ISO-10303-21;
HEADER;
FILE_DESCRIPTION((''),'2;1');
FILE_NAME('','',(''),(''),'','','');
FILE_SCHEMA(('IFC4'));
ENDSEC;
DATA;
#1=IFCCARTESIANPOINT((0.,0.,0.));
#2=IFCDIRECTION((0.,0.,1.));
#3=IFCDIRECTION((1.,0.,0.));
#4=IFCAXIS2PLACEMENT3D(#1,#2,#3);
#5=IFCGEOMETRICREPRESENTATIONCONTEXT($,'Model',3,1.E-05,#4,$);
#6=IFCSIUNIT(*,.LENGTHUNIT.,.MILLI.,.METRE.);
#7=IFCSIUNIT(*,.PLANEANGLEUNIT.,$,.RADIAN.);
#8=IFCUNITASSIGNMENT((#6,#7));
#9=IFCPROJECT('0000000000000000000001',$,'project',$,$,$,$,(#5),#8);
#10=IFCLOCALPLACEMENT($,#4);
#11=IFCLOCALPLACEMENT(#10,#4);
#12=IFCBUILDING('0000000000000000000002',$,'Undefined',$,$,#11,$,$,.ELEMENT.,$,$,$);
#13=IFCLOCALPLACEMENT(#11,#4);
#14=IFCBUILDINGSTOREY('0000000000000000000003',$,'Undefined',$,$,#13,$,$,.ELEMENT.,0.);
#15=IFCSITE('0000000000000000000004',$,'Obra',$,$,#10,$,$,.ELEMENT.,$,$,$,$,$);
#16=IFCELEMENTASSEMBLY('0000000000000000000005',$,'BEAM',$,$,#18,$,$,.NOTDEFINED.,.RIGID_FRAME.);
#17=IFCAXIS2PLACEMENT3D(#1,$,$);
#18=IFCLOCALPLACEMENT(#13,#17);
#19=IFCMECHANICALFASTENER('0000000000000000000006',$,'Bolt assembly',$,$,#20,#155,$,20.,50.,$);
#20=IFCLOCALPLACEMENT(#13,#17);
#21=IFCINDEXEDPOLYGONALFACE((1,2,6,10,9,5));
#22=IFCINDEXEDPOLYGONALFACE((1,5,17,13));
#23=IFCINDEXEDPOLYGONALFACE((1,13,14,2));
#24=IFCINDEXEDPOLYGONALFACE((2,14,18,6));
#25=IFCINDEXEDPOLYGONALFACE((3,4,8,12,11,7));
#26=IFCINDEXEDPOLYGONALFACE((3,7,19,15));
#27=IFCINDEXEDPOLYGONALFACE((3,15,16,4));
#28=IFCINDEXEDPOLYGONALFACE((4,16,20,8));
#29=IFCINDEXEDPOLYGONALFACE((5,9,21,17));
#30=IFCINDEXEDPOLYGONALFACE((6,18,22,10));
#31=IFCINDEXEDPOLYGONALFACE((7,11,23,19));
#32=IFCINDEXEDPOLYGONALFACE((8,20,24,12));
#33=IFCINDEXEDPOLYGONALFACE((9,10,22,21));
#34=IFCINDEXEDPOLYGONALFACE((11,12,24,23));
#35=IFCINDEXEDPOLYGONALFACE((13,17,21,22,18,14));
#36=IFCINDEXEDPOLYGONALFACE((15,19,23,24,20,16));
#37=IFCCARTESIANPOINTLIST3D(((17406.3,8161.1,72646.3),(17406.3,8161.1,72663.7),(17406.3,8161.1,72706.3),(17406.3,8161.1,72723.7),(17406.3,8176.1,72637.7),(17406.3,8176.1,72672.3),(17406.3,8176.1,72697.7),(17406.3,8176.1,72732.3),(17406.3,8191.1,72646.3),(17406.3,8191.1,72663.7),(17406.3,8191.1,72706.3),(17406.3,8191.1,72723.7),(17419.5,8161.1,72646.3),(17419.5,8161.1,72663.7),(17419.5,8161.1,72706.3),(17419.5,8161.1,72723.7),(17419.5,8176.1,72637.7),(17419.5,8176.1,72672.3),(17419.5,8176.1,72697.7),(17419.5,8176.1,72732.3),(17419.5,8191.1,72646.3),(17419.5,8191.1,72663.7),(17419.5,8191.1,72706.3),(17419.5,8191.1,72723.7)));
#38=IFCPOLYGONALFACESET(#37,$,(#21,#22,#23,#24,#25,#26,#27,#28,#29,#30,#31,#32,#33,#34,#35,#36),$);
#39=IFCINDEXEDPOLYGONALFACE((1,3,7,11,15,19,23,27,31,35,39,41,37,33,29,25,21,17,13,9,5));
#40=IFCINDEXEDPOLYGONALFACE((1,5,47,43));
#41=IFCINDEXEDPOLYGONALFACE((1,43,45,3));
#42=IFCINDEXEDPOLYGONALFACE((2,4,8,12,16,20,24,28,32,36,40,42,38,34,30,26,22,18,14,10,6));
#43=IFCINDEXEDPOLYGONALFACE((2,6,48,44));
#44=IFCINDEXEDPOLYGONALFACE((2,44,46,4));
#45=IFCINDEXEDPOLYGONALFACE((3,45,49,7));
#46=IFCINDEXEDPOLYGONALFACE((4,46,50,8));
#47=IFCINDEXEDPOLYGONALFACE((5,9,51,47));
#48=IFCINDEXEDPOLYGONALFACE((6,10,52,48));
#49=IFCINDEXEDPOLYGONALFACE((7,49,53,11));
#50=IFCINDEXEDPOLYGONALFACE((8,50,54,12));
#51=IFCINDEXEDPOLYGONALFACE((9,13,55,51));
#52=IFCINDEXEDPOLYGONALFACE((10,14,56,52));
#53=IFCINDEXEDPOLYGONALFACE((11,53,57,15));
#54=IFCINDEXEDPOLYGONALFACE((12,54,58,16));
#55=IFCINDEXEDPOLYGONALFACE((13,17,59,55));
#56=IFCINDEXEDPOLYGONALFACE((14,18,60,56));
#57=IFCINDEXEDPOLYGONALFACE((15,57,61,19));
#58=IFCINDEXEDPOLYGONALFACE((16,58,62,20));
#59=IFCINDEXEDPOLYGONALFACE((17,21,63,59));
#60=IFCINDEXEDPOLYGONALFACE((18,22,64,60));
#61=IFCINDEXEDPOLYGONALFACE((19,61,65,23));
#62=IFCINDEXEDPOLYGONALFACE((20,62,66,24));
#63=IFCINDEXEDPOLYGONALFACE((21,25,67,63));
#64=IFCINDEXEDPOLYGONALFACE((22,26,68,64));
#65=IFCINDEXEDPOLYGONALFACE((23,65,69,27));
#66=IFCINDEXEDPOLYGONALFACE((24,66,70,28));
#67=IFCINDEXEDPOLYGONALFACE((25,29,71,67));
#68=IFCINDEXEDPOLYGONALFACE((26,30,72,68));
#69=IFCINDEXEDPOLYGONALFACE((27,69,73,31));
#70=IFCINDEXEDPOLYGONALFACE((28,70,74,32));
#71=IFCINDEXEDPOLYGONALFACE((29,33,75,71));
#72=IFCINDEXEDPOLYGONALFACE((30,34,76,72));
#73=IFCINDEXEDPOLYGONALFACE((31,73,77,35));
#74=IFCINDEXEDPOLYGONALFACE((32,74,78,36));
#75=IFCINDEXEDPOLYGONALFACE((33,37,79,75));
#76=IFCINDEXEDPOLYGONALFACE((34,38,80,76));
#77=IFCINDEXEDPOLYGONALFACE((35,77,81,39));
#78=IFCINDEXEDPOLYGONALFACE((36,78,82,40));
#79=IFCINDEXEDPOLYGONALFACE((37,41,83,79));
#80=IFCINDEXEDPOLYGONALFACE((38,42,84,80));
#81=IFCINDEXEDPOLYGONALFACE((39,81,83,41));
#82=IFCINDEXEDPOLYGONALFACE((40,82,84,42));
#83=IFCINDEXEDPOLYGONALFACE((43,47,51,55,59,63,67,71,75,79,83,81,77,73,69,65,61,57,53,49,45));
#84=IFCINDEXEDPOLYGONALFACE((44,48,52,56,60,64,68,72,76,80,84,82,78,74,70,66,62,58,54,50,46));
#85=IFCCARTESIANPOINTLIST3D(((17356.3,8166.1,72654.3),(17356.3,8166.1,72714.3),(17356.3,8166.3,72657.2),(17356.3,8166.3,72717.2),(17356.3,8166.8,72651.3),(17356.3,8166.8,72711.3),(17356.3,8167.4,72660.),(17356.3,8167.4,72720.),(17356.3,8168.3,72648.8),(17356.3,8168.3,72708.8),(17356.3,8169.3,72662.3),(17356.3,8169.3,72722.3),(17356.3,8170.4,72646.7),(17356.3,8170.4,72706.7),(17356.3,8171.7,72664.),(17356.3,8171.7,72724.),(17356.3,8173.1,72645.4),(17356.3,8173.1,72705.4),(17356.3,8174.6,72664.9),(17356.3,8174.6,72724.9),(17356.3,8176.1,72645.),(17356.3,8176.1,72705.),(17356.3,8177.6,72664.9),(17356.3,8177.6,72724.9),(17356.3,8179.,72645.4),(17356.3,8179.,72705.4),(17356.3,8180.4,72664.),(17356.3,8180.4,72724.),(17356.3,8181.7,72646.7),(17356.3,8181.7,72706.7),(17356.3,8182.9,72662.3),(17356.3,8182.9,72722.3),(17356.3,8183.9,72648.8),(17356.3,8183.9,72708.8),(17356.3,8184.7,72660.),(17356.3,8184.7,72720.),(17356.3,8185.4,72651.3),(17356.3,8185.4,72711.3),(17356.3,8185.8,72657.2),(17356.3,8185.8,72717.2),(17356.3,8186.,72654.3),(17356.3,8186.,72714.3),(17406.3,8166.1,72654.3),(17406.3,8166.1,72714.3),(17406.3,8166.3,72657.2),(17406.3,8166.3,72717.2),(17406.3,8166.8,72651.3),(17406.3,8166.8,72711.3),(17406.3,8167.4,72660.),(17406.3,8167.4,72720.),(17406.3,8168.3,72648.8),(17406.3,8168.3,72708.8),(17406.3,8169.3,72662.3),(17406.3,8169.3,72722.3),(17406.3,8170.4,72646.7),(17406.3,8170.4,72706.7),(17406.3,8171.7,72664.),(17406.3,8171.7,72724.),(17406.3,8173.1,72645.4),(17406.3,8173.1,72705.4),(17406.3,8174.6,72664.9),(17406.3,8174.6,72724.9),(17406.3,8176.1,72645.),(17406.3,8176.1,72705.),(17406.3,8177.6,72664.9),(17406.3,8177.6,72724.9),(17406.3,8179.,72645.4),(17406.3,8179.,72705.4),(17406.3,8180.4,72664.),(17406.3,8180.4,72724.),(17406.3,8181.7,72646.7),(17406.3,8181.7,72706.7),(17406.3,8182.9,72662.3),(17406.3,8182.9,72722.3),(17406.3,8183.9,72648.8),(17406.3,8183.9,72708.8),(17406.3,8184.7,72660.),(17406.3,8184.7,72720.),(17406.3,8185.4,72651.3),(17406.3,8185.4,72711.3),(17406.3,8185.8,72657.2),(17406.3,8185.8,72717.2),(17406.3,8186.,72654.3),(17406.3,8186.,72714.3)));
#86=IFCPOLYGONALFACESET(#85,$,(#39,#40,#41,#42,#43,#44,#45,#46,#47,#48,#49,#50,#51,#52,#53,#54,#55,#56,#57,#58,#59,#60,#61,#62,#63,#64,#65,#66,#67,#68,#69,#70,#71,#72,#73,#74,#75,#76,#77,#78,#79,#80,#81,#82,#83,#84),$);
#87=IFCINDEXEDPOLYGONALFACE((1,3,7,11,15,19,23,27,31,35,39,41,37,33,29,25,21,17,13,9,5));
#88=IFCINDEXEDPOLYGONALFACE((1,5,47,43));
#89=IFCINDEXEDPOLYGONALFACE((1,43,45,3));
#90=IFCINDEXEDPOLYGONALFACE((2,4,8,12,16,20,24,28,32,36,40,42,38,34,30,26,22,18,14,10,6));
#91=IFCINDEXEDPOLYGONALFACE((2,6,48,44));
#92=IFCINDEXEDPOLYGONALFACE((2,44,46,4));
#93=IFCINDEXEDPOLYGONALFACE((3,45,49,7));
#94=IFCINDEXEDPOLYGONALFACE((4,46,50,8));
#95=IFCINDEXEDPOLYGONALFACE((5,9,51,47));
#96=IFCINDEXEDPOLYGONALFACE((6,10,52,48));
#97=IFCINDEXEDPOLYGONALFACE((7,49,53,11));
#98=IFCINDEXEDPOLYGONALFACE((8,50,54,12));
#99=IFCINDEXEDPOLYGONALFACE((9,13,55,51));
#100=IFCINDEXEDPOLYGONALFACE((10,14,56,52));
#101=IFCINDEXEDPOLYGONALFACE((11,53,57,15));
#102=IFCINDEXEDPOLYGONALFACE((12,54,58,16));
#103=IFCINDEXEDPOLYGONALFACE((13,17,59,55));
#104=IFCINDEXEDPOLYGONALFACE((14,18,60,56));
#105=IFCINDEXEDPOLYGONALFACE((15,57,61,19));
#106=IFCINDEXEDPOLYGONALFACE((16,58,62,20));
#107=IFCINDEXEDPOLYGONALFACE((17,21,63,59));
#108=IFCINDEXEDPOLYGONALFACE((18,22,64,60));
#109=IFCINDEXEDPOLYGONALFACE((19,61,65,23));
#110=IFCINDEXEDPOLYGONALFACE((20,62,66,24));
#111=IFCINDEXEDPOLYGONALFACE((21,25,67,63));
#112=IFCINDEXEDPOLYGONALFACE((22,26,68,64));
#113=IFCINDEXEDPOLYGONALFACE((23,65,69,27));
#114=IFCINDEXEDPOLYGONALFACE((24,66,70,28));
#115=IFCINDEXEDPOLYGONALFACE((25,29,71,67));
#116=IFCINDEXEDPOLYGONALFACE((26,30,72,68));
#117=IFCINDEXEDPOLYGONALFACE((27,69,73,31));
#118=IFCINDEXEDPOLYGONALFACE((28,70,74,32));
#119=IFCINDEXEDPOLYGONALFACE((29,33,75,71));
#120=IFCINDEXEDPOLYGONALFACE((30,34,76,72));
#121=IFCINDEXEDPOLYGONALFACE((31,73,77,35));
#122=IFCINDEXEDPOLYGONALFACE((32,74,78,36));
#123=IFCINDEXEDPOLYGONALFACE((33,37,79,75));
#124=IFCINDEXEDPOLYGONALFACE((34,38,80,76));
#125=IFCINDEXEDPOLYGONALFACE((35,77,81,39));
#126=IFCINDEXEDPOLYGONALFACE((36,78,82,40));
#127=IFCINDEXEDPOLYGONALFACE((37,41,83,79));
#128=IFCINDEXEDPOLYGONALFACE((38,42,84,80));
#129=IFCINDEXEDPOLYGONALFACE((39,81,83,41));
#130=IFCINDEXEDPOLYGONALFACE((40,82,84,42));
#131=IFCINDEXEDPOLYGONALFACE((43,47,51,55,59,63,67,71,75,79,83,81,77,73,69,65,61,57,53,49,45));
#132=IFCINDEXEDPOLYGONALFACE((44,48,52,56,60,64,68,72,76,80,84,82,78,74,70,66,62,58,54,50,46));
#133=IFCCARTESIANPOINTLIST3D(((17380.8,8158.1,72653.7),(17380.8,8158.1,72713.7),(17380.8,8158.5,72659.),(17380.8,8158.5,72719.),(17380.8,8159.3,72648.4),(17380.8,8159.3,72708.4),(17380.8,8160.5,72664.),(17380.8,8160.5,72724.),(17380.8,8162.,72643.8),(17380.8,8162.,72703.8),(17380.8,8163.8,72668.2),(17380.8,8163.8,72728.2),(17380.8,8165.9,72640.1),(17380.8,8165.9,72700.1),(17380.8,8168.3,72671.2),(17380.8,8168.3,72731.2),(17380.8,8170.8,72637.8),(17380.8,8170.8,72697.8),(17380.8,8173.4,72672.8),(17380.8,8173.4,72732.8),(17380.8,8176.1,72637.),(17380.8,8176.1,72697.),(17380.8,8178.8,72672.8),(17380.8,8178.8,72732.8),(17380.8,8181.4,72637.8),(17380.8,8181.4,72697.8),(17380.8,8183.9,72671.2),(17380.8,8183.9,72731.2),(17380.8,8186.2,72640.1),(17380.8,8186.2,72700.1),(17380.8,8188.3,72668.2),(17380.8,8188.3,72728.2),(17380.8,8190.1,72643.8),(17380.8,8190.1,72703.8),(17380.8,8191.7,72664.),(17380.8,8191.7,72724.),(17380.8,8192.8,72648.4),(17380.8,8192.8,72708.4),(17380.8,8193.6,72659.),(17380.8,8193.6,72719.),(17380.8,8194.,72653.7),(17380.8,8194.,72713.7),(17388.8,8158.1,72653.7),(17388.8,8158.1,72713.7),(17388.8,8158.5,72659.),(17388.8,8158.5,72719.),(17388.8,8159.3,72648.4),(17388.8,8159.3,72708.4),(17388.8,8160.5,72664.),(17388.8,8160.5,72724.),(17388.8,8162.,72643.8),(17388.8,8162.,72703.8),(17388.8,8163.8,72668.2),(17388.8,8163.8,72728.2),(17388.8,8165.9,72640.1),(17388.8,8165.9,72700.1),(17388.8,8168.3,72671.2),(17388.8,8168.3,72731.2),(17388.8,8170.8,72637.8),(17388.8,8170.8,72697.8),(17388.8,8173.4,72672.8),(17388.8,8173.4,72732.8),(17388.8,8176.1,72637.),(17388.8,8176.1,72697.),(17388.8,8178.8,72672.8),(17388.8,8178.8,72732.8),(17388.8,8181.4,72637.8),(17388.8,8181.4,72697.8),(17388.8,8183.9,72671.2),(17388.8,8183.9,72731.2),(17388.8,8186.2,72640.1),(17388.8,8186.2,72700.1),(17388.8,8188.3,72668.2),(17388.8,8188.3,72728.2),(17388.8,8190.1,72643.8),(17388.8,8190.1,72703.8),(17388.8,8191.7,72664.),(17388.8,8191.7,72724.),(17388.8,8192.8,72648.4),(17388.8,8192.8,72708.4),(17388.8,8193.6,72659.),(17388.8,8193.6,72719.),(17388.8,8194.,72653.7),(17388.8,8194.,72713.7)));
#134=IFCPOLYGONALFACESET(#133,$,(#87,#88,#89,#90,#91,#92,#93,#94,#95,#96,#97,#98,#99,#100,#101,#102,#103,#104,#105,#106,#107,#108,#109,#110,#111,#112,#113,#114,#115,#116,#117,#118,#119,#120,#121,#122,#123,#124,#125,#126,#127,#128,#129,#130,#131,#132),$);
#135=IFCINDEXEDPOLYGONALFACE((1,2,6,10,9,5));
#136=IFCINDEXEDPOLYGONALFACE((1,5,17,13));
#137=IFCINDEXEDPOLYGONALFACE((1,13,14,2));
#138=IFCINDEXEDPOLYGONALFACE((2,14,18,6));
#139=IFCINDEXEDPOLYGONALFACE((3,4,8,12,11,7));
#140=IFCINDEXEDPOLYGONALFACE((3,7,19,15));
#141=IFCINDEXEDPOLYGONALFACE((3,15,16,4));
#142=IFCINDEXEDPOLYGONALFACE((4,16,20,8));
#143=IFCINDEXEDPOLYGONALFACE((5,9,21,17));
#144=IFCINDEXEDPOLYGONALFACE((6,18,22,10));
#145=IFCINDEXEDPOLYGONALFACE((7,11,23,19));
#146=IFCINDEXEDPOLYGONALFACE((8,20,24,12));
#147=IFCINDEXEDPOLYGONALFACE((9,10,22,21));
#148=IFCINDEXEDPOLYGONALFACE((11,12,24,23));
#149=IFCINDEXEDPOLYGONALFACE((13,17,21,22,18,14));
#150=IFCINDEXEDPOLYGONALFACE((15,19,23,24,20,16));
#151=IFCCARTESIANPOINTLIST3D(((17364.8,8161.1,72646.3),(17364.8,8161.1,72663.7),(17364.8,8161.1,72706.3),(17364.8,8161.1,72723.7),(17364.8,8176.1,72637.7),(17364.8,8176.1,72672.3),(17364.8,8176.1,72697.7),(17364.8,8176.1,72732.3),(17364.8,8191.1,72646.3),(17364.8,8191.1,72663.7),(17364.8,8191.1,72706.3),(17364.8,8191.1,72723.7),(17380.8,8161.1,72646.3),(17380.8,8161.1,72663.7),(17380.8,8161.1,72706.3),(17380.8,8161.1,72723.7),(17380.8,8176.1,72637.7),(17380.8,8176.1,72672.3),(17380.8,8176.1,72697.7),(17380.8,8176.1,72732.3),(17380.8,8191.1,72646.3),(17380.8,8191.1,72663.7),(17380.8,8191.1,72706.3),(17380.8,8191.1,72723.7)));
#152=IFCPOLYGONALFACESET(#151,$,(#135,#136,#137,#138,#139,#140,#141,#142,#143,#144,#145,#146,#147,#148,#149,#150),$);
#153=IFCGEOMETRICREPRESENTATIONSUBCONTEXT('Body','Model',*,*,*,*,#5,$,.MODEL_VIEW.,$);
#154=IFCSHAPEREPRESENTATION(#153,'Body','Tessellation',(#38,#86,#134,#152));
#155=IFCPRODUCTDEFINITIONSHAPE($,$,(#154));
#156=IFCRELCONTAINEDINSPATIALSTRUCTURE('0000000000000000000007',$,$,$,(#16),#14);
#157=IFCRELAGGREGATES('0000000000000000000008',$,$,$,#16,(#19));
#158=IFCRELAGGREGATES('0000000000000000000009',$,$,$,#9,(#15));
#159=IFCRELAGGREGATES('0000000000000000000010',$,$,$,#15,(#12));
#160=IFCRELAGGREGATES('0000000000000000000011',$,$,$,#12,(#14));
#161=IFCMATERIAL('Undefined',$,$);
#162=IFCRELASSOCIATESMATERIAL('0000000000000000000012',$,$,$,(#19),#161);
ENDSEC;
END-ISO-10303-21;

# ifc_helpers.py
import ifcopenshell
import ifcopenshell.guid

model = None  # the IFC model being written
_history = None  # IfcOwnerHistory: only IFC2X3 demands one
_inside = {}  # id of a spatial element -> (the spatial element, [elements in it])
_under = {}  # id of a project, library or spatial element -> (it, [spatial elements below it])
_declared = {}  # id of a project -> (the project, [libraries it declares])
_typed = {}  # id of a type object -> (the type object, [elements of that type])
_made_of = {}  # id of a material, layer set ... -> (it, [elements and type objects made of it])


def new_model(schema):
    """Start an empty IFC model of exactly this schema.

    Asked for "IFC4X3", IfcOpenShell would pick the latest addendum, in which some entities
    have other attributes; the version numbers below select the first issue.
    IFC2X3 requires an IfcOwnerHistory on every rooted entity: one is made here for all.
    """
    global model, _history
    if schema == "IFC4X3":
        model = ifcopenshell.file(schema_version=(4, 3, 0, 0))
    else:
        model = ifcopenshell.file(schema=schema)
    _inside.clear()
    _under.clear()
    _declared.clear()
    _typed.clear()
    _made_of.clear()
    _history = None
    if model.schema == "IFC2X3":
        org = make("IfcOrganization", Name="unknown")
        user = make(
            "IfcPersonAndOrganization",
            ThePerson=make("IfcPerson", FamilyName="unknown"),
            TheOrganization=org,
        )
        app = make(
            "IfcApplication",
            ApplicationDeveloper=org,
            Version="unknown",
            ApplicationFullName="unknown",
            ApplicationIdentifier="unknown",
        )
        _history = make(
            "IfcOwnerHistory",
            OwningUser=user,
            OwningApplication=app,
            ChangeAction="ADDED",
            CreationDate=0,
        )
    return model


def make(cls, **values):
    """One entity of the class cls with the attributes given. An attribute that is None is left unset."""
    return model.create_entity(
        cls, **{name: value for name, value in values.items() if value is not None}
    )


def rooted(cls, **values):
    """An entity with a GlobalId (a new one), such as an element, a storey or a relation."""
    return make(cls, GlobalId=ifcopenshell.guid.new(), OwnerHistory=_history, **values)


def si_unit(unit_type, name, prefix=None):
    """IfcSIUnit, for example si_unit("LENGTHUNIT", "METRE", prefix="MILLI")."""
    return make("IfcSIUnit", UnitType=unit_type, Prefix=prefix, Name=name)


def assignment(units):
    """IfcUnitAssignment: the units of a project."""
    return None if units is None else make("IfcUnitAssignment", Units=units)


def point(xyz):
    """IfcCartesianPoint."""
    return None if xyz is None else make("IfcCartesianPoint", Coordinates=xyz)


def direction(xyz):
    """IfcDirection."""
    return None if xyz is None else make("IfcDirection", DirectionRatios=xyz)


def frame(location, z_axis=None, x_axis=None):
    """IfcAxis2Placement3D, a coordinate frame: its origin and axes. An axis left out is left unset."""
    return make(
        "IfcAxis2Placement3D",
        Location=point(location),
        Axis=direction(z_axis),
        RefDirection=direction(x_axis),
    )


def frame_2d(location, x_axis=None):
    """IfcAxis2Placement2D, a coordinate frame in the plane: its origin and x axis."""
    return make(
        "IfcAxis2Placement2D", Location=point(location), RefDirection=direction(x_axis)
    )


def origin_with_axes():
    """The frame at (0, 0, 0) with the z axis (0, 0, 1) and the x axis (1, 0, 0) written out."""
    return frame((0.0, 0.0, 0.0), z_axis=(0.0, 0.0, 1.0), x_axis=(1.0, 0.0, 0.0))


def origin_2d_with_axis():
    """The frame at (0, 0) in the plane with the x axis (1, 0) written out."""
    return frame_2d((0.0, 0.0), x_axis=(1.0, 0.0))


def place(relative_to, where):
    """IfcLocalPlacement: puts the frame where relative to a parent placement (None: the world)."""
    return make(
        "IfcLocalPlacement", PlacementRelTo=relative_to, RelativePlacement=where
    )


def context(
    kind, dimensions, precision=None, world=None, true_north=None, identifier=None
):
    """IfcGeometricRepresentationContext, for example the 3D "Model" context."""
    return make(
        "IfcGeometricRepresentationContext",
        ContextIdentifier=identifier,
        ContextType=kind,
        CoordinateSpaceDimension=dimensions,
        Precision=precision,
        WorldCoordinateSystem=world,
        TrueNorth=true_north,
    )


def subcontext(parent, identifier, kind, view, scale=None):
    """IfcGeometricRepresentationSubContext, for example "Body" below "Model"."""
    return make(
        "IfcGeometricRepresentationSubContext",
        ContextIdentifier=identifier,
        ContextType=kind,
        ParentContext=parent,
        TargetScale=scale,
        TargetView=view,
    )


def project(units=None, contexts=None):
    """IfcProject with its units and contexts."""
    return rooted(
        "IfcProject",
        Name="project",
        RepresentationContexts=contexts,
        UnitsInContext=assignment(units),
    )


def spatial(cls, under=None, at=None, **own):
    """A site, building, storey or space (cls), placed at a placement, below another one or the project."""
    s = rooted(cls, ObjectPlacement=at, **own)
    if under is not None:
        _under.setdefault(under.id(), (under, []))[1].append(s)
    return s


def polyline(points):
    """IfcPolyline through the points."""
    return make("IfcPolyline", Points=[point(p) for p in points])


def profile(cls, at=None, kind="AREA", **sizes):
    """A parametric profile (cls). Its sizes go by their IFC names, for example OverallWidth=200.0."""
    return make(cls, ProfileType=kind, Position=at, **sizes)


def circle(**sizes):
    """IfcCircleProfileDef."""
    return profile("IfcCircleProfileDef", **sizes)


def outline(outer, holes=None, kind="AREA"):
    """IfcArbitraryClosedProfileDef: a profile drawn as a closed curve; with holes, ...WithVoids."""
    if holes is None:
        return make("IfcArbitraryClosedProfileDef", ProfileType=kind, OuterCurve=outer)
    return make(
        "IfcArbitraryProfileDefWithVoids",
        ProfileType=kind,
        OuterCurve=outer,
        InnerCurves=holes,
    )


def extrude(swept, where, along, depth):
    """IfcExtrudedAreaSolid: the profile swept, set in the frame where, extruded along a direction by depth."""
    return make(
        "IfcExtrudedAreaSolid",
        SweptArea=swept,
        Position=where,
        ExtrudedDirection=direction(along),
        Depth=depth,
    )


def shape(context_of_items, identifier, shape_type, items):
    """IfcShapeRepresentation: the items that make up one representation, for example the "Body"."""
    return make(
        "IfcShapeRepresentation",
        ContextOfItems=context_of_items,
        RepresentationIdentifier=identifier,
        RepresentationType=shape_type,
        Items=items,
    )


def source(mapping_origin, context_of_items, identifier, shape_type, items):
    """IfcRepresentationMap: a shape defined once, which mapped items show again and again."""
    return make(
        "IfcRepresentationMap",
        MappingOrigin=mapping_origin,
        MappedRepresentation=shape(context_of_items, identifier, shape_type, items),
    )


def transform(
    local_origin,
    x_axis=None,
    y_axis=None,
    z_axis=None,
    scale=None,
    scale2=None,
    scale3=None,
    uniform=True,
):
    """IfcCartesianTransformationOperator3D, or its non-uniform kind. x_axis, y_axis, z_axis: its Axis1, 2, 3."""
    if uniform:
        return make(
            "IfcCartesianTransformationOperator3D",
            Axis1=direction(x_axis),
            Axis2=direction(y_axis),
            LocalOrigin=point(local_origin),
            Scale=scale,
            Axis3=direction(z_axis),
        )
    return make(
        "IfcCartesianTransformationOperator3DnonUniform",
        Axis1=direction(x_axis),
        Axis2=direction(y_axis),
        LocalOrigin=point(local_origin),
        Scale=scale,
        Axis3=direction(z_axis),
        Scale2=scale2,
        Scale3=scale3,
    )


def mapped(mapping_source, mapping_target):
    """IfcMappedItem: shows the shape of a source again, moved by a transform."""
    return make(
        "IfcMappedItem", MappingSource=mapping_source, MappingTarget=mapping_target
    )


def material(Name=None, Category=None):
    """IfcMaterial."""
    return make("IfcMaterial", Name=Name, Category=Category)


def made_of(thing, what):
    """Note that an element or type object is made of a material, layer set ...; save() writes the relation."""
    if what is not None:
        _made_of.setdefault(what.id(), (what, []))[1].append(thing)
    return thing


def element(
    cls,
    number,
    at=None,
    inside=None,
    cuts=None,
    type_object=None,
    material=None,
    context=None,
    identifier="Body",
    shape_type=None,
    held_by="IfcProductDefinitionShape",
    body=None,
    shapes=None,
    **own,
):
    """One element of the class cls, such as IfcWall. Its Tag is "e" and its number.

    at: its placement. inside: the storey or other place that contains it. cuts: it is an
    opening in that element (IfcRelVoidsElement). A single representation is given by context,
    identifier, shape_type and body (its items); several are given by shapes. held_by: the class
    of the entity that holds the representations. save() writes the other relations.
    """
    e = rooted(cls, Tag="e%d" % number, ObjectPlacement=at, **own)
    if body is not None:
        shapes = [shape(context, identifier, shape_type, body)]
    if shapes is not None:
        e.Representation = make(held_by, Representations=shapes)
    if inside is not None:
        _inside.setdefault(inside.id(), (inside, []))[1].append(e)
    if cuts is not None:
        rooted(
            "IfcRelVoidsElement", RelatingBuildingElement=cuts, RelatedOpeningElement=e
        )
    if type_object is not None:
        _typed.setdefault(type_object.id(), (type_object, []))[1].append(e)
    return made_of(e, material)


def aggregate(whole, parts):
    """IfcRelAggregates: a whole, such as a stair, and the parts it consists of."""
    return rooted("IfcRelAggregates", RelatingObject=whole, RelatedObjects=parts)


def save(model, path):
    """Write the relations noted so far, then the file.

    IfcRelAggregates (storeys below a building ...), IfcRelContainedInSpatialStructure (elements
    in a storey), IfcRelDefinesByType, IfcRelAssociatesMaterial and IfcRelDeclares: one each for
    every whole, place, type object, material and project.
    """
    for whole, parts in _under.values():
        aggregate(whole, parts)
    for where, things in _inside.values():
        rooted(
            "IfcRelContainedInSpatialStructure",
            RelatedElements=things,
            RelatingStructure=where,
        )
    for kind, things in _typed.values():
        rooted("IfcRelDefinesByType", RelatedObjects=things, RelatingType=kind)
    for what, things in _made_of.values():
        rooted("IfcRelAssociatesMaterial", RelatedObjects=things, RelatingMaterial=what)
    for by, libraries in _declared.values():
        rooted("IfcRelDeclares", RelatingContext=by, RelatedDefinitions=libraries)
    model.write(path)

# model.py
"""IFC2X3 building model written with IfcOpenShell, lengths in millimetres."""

from ifc_helpers import new_model, si_unit, frame, origin_with_axes, origin_2d_with_axis, place, context, subcontext, project, spatial, polyline, circle, outline, extrude, source, transform, mapped, material, element, aggregate, save


model = new_model("IFC2X3")

# Units and contexts
model_context = context("Model", 3, precision=1e-05, world=origin_with_axes())
body_context = subcontext(model_context, "Body", "Model", "MODEL_VIEW")
ifc_project = project(units=[si_unit("LENGTHUNIT", "METRE", prefix="MILLI"), si_unit("PLANEANGLEUNIT", "RADIAN")], contexts=[model_context])

# Site, building, storey
site_placement = place(None, origin_with_axes())
site = spatial("IfcSite", under=ifc_project, at=site_placement, Name="Obra", CompositionType="ELEMENT")
building_placement = place(site_placement, origin_with_axes())
building = spatial("IfcBuilding", under=site, at=building_placement, Name="Undefined", CompositionType="ELEMENT")
storey_placement = place(building_placement, origin_with_axes())
storey = spatial("IfcBuildingStorey", under=building, at=storey_placement, Name="Undefined", CompositionType="ELEMENT", Elevation=0.0)

# Shared definitions
ifc_material = material(Name="Undefined")

# Shared definitions
shared_shape_1 = source(origin_with_axes(), body_context, "Body", "SweptSolid", [
    extrude(outline(polyline([(17.3, 0.0), (8.7, 15.0), (-8.7, 15.0), (-17.3, 0.0), (-8.7, -15.0), (8.7, -15.0), (17.3, 0.0)])), frame((0.0, -27.0, 0.0), z_axis=(0.0, 1.0, 0.0), x_axis=(1.0, 0.0, 0.0)), (0.0, 0.0, 1.0), 13.2),
    extrude(circle(Radius=10.0, at=origin_2d_with_axis()), frame((0.0, -13.8, 0.0), z_axis=(0.0, 1.0, 0.0), x_axis=(1.0, 0.0, 0.0)), (0.0, 0.0, 1.0), 50.0),
    extrude(circle(Radius=18.0, at=origin_2d_with_axis()), frame((0.0, 3.7, 0.0), z_axis=(0.0, 1.0, 0.0), x_axis=(1.0, 0.0, 0.0)), (0.0, 0.0, 1.0), 8.0),
    extrude(outline(polyline([(17.3, 0.0), (8.7, 15.0), (-8.7, 15.0), (-17.3, 0.0), (-8.7, -15.0), (8.7, -15.0), (17.3, 0.0)])), frame((0.0, 11.7, 0.0), z_axis=(0.0, 1.0, 0.0), x_axis=(1.0, 0.0, 0.0)), (0.0, 0.0, 1.0), 16.0),
])

# Element assembly, mechanical fastener
assembly_1_placement = place(storey_placement, origin_with_axes())
assembly_1 = element("IfcElementAssembly", 1, at=assembly_1_placement, inside=storey, Name="BEAM", AssemblyPlace="NOTDEFINED", PredefinedType="RIGID_FRAME")
mechanical_fastener_1_placement = place(assembly_1_placement, frame((17392.6, 8136.1, 72850.0), z_axis=(0.0, 1.0, 0.0), x_axis=(0.0, 0.0, -1.0)))
mechanical_fastener_1 = element("IfcMechanicalFastener", 2, at=mechanical_fastener_1_placement, material=ifc_material, Name="Bolt assembly", NominalDiameter=20.0, NominalLength=50.0, context=body_context, shape_type="MappedRepresentation", body=[
    mapped(shared_shape_1, transform((135.0, 0.0, 40.0))),
    mapped(shared_shape_1, transform((195.0, 0.0, 40.0))),
])
aggregate(assembly_1, [mechanical_fastener_1])

save(model, "model.ifc")
